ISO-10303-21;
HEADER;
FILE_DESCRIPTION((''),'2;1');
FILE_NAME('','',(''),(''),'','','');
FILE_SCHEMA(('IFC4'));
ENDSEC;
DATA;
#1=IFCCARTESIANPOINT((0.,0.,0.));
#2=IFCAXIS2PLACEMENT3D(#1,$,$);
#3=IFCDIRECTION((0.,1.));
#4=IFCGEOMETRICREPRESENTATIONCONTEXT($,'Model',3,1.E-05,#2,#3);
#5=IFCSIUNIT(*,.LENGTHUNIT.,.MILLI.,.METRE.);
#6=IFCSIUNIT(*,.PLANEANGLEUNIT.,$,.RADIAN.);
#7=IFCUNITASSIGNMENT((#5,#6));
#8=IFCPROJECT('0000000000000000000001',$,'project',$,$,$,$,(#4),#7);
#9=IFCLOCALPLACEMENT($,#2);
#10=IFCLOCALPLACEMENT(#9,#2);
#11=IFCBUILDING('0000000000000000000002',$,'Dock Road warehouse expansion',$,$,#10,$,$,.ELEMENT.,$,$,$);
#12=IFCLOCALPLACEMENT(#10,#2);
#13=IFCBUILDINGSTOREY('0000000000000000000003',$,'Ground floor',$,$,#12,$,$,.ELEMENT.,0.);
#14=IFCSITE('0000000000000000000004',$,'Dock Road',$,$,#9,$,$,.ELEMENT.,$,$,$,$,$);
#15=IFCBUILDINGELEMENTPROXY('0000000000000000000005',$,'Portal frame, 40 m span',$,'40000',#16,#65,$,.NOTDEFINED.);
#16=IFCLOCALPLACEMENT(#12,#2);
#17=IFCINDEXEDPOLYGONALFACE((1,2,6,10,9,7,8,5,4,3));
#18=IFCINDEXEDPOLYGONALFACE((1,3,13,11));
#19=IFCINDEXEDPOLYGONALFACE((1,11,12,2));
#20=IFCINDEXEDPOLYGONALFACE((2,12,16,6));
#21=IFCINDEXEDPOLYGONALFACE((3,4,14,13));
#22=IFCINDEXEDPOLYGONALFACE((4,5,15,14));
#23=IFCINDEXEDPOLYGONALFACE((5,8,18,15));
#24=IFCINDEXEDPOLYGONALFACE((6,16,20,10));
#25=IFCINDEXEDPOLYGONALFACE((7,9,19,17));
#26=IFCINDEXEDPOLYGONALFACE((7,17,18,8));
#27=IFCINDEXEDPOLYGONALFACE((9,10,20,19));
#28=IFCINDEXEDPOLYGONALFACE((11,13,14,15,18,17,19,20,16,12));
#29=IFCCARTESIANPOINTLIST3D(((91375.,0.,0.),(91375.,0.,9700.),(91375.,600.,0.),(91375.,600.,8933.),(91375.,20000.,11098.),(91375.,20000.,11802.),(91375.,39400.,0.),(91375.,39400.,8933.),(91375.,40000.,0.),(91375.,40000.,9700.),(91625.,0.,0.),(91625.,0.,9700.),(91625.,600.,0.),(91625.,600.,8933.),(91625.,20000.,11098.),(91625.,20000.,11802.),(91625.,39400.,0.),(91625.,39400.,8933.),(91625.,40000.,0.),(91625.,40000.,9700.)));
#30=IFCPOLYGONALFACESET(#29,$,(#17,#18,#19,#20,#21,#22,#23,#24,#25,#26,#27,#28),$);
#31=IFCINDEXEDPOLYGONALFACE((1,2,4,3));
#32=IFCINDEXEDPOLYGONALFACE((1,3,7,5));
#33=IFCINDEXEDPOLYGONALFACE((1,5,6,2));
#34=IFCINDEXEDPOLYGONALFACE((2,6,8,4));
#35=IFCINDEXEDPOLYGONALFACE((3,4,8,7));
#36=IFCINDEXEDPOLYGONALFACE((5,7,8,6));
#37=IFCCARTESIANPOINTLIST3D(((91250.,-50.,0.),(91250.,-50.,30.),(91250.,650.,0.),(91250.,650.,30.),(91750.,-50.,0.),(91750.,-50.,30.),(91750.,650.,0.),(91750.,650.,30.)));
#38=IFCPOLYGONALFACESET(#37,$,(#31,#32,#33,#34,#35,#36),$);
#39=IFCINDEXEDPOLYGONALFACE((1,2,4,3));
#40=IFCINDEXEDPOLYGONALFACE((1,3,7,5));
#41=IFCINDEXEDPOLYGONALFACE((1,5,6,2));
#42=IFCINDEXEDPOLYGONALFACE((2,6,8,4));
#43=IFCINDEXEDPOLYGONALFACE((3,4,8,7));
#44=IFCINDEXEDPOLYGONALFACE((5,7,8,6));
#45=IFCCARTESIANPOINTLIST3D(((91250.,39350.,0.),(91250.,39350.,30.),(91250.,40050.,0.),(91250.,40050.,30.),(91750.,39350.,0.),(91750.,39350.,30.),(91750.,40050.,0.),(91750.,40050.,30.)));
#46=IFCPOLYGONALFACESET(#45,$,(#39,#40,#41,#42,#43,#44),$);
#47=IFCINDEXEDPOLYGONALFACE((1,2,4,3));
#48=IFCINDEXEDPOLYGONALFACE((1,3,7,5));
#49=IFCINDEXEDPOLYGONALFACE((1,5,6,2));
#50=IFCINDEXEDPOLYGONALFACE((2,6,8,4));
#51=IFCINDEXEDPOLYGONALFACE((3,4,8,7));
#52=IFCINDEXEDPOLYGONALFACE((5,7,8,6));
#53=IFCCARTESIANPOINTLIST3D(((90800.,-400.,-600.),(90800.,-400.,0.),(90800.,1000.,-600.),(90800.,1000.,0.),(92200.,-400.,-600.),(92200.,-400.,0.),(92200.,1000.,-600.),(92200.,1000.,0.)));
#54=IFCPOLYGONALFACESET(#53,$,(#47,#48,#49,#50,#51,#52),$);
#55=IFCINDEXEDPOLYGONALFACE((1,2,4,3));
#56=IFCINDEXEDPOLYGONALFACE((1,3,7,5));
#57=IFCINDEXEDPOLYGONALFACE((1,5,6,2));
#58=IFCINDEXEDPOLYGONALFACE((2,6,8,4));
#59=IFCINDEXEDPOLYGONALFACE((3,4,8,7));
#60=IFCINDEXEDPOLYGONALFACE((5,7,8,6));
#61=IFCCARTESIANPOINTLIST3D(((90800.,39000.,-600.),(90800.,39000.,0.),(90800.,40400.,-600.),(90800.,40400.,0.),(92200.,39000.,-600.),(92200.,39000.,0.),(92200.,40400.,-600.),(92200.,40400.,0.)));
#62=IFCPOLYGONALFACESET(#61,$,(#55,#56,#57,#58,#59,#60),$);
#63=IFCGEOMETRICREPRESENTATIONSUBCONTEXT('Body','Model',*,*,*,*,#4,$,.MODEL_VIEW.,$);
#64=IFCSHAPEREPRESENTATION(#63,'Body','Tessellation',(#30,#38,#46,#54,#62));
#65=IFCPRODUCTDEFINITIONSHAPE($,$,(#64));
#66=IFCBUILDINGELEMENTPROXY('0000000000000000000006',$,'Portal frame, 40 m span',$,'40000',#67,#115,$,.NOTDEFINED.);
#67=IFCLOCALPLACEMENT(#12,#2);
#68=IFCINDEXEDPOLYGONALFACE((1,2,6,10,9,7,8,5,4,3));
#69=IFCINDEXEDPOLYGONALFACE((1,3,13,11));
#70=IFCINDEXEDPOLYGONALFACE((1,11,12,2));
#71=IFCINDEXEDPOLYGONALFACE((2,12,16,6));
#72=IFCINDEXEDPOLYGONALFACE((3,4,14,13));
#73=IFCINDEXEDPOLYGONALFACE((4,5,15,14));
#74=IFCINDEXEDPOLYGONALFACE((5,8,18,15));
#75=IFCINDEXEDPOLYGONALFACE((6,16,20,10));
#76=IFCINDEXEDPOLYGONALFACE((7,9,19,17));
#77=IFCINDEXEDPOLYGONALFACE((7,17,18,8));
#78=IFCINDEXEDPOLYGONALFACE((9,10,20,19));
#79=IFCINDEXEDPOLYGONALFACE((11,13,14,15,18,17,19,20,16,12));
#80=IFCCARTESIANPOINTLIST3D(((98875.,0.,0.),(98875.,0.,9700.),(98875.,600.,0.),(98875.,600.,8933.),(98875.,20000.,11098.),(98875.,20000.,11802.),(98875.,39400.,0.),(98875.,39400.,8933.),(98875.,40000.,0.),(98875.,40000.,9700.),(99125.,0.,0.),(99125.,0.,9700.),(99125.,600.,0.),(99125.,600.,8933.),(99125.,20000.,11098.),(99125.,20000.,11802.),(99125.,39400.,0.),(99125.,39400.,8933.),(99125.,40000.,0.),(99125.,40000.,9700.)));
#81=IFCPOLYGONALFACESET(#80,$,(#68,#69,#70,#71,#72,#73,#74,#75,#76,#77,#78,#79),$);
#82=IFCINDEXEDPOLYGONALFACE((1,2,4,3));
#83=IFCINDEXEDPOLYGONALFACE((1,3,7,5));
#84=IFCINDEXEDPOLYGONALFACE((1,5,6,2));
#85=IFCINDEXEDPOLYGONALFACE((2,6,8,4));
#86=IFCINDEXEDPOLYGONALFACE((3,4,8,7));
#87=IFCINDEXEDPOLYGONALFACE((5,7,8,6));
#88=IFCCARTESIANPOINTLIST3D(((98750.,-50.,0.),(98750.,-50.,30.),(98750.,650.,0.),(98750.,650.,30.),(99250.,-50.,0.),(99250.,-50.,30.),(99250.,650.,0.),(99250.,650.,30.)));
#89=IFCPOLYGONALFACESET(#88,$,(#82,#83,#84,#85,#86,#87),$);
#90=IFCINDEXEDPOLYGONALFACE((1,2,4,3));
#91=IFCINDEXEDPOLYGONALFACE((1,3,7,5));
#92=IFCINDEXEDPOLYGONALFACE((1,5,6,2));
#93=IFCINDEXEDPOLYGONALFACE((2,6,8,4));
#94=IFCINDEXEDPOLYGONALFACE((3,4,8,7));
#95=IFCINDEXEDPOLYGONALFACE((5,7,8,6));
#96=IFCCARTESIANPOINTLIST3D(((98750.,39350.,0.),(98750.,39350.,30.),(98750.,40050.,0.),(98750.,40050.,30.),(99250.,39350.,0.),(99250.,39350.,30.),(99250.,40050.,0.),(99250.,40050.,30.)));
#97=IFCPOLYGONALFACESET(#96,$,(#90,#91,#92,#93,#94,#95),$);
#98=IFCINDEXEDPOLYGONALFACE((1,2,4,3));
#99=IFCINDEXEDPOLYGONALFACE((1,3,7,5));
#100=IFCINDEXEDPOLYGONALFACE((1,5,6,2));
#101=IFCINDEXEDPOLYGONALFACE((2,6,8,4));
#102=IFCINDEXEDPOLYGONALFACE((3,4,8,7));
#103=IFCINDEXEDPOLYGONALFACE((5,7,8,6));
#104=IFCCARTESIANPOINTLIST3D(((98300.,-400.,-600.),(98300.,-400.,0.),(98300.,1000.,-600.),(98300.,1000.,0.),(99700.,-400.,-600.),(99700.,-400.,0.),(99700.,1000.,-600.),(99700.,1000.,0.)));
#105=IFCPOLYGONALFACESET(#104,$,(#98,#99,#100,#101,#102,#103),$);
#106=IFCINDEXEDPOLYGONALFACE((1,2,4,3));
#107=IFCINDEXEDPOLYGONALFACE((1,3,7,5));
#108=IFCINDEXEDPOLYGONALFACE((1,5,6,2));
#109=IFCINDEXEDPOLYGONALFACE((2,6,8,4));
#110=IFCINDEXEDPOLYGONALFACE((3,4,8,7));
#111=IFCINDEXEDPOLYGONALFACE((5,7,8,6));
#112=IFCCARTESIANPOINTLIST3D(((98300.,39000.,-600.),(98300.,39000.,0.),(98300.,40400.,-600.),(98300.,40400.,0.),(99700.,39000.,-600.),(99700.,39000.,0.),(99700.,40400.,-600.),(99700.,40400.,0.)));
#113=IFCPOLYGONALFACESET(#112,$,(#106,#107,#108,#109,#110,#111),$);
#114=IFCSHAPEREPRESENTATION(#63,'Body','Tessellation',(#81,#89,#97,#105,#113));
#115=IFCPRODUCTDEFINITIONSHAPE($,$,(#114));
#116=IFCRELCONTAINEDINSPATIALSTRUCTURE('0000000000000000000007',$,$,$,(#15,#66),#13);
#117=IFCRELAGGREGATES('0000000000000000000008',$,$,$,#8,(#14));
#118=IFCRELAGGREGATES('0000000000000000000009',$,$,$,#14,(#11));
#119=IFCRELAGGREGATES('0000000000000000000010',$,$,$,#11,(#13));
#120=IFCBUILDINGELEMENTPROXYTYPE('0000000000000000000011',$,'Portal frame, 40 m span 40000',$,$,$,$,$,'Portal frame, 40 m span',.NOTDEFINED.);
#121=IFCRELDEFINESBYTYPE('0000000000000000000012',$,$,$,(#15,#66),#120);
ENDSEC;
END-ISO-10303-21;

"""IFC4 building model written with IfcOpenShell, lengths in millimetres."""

from ifc_helpers import new_model, si_unit, direction, frame, origin, place, context, subcontext, project, spatial, polyline, outline, extrude, source, transform, mapped, type_object, type_shapes, element, save


model = new_model("IFC4")

# Units and contexts
model_context = context("Model", 3, precision=1e-05, world=origin(), true_north=direction((0.0, 1.0)))
body_context = subcontext(model_context, "Body", "Model", "MODEL_VIEW")
ifc_project = project(units=[si_unit("LENGTHUNIT", "METRE", prefix="MILLI"), si_unit("PLANEANGLEUNIT", "RADIAN")], contexts=[model_context])

# Site, building, storey
site_placement = place(None, origin())
site = spatial("IfcSite", under=ifc_project, at=site_placement, Name="Dock Road", CompositionType="ELEMENT")
building_placement = place(site_placement, origin())
building = spatial("IfcBuilding", under=site, at=building_placement, Name="Dock Road warehouse expansion", CompositionType="ELEMENT")
storey_placement = place(building_placement, origin())
storey = spatial("IfcBuildingStorey", under=building, at=storey_placement, Name="Ground floor", CompositionType="ELEMENT", Elevation=0.0)

# Building element proxies
building_element_proxy_type_1 = type_object("IfcBuildingElementProxyType", Name="Portal frame, 40 m span 40000", ElementType="Portal frame, 40 m span", PredefinedType="NOTDEFINED")
shared_shape_1 = source(origin(), body_context, "Body", "SweptSolid", [
    extrude(outline(polyline([(0.0, 0.0), (0.0, 9700.0), (20000.0, 11802.0), (40000.0, 9700.0), (40000.0, 0.0), (39400.0, 0.0), (39400.0, 8933.0), (20000.0, 11098.0), (600.0, 8933.0), (600.0, 0.0), (0.0, 0.0)])), frame((-125.0, 0.0, 0.0), z_axis=(1.0, 0.0, 0.0), x_axis=(0.0, 1.0, 0.0)), (0.0, 0.0, 1.0), 250.0),
    extrude(outline(polyline([(-250.0, -50.0), (250.0, -50.0), (250.0, 650.0), (-250.0, 650.0), (-250.0, -50.0)])), origin(), (0.0, 0.0, 1.0), 30.0),
    extrude(outline(polyline([(-250.0, 39350.0), (250.0, 39350.0), (250.0, 40050.0), (-250.0, 40050.0), (-250.0, 39350.0)])), origin(), (0.0, 0.0, 1.0), 30.0),
    extrude(outline(polyline([(-700.0, -400.0), (700.0, -400.0), (700.0, 1000.0), (-700.0, 1000.0), (-700.0, -400.0)])), frame((0.0, 0.0, -600.0)), (0.0, 0.0, 1.0), 600.0),
    extrude(outline(polyline([(-700.0, 39000.0), (700.0, 39000.0), (700.0, 40400.0), (-700.0, 40400.0), (-700.0, 39000.0)])), frame((0.0, 0.0, -600.0)), (0.0, 0.0, 1.0), 600.0),
])
type_shapes(building_element_proxy_type_1, [shared_shape_1])
for number, where, z_axis, x_axis, name in (
    (1, (91500.0, 0.0, 0.0), (0.0, 0.0, 1.0), (1.0, 0.0, 0.0), "Portal frame, 40 m span"),
    (2, (99000.0, 0.0, 0.0), (0.0, 0.0, 1.0), (1.0, 0.0, 0.0), "Portal frame, 40 m span"),
):
    element("IfcBuildingElementProxy", number, at=place(storey_placement, frame(where, z_axis=z_axis, x_axis=x_axis)), inside=storey, type_object=building_element_proxy_type_1, Name=name, ObjectType="40000", PredefinedType="NOTDEFINED", context=body_context, shape_type="MappedRepresentation", body=[
        mapped(shared_shape_1, transform((0.0, 0.0, 0.0))),
    ])

save(model, "model.ifc")
